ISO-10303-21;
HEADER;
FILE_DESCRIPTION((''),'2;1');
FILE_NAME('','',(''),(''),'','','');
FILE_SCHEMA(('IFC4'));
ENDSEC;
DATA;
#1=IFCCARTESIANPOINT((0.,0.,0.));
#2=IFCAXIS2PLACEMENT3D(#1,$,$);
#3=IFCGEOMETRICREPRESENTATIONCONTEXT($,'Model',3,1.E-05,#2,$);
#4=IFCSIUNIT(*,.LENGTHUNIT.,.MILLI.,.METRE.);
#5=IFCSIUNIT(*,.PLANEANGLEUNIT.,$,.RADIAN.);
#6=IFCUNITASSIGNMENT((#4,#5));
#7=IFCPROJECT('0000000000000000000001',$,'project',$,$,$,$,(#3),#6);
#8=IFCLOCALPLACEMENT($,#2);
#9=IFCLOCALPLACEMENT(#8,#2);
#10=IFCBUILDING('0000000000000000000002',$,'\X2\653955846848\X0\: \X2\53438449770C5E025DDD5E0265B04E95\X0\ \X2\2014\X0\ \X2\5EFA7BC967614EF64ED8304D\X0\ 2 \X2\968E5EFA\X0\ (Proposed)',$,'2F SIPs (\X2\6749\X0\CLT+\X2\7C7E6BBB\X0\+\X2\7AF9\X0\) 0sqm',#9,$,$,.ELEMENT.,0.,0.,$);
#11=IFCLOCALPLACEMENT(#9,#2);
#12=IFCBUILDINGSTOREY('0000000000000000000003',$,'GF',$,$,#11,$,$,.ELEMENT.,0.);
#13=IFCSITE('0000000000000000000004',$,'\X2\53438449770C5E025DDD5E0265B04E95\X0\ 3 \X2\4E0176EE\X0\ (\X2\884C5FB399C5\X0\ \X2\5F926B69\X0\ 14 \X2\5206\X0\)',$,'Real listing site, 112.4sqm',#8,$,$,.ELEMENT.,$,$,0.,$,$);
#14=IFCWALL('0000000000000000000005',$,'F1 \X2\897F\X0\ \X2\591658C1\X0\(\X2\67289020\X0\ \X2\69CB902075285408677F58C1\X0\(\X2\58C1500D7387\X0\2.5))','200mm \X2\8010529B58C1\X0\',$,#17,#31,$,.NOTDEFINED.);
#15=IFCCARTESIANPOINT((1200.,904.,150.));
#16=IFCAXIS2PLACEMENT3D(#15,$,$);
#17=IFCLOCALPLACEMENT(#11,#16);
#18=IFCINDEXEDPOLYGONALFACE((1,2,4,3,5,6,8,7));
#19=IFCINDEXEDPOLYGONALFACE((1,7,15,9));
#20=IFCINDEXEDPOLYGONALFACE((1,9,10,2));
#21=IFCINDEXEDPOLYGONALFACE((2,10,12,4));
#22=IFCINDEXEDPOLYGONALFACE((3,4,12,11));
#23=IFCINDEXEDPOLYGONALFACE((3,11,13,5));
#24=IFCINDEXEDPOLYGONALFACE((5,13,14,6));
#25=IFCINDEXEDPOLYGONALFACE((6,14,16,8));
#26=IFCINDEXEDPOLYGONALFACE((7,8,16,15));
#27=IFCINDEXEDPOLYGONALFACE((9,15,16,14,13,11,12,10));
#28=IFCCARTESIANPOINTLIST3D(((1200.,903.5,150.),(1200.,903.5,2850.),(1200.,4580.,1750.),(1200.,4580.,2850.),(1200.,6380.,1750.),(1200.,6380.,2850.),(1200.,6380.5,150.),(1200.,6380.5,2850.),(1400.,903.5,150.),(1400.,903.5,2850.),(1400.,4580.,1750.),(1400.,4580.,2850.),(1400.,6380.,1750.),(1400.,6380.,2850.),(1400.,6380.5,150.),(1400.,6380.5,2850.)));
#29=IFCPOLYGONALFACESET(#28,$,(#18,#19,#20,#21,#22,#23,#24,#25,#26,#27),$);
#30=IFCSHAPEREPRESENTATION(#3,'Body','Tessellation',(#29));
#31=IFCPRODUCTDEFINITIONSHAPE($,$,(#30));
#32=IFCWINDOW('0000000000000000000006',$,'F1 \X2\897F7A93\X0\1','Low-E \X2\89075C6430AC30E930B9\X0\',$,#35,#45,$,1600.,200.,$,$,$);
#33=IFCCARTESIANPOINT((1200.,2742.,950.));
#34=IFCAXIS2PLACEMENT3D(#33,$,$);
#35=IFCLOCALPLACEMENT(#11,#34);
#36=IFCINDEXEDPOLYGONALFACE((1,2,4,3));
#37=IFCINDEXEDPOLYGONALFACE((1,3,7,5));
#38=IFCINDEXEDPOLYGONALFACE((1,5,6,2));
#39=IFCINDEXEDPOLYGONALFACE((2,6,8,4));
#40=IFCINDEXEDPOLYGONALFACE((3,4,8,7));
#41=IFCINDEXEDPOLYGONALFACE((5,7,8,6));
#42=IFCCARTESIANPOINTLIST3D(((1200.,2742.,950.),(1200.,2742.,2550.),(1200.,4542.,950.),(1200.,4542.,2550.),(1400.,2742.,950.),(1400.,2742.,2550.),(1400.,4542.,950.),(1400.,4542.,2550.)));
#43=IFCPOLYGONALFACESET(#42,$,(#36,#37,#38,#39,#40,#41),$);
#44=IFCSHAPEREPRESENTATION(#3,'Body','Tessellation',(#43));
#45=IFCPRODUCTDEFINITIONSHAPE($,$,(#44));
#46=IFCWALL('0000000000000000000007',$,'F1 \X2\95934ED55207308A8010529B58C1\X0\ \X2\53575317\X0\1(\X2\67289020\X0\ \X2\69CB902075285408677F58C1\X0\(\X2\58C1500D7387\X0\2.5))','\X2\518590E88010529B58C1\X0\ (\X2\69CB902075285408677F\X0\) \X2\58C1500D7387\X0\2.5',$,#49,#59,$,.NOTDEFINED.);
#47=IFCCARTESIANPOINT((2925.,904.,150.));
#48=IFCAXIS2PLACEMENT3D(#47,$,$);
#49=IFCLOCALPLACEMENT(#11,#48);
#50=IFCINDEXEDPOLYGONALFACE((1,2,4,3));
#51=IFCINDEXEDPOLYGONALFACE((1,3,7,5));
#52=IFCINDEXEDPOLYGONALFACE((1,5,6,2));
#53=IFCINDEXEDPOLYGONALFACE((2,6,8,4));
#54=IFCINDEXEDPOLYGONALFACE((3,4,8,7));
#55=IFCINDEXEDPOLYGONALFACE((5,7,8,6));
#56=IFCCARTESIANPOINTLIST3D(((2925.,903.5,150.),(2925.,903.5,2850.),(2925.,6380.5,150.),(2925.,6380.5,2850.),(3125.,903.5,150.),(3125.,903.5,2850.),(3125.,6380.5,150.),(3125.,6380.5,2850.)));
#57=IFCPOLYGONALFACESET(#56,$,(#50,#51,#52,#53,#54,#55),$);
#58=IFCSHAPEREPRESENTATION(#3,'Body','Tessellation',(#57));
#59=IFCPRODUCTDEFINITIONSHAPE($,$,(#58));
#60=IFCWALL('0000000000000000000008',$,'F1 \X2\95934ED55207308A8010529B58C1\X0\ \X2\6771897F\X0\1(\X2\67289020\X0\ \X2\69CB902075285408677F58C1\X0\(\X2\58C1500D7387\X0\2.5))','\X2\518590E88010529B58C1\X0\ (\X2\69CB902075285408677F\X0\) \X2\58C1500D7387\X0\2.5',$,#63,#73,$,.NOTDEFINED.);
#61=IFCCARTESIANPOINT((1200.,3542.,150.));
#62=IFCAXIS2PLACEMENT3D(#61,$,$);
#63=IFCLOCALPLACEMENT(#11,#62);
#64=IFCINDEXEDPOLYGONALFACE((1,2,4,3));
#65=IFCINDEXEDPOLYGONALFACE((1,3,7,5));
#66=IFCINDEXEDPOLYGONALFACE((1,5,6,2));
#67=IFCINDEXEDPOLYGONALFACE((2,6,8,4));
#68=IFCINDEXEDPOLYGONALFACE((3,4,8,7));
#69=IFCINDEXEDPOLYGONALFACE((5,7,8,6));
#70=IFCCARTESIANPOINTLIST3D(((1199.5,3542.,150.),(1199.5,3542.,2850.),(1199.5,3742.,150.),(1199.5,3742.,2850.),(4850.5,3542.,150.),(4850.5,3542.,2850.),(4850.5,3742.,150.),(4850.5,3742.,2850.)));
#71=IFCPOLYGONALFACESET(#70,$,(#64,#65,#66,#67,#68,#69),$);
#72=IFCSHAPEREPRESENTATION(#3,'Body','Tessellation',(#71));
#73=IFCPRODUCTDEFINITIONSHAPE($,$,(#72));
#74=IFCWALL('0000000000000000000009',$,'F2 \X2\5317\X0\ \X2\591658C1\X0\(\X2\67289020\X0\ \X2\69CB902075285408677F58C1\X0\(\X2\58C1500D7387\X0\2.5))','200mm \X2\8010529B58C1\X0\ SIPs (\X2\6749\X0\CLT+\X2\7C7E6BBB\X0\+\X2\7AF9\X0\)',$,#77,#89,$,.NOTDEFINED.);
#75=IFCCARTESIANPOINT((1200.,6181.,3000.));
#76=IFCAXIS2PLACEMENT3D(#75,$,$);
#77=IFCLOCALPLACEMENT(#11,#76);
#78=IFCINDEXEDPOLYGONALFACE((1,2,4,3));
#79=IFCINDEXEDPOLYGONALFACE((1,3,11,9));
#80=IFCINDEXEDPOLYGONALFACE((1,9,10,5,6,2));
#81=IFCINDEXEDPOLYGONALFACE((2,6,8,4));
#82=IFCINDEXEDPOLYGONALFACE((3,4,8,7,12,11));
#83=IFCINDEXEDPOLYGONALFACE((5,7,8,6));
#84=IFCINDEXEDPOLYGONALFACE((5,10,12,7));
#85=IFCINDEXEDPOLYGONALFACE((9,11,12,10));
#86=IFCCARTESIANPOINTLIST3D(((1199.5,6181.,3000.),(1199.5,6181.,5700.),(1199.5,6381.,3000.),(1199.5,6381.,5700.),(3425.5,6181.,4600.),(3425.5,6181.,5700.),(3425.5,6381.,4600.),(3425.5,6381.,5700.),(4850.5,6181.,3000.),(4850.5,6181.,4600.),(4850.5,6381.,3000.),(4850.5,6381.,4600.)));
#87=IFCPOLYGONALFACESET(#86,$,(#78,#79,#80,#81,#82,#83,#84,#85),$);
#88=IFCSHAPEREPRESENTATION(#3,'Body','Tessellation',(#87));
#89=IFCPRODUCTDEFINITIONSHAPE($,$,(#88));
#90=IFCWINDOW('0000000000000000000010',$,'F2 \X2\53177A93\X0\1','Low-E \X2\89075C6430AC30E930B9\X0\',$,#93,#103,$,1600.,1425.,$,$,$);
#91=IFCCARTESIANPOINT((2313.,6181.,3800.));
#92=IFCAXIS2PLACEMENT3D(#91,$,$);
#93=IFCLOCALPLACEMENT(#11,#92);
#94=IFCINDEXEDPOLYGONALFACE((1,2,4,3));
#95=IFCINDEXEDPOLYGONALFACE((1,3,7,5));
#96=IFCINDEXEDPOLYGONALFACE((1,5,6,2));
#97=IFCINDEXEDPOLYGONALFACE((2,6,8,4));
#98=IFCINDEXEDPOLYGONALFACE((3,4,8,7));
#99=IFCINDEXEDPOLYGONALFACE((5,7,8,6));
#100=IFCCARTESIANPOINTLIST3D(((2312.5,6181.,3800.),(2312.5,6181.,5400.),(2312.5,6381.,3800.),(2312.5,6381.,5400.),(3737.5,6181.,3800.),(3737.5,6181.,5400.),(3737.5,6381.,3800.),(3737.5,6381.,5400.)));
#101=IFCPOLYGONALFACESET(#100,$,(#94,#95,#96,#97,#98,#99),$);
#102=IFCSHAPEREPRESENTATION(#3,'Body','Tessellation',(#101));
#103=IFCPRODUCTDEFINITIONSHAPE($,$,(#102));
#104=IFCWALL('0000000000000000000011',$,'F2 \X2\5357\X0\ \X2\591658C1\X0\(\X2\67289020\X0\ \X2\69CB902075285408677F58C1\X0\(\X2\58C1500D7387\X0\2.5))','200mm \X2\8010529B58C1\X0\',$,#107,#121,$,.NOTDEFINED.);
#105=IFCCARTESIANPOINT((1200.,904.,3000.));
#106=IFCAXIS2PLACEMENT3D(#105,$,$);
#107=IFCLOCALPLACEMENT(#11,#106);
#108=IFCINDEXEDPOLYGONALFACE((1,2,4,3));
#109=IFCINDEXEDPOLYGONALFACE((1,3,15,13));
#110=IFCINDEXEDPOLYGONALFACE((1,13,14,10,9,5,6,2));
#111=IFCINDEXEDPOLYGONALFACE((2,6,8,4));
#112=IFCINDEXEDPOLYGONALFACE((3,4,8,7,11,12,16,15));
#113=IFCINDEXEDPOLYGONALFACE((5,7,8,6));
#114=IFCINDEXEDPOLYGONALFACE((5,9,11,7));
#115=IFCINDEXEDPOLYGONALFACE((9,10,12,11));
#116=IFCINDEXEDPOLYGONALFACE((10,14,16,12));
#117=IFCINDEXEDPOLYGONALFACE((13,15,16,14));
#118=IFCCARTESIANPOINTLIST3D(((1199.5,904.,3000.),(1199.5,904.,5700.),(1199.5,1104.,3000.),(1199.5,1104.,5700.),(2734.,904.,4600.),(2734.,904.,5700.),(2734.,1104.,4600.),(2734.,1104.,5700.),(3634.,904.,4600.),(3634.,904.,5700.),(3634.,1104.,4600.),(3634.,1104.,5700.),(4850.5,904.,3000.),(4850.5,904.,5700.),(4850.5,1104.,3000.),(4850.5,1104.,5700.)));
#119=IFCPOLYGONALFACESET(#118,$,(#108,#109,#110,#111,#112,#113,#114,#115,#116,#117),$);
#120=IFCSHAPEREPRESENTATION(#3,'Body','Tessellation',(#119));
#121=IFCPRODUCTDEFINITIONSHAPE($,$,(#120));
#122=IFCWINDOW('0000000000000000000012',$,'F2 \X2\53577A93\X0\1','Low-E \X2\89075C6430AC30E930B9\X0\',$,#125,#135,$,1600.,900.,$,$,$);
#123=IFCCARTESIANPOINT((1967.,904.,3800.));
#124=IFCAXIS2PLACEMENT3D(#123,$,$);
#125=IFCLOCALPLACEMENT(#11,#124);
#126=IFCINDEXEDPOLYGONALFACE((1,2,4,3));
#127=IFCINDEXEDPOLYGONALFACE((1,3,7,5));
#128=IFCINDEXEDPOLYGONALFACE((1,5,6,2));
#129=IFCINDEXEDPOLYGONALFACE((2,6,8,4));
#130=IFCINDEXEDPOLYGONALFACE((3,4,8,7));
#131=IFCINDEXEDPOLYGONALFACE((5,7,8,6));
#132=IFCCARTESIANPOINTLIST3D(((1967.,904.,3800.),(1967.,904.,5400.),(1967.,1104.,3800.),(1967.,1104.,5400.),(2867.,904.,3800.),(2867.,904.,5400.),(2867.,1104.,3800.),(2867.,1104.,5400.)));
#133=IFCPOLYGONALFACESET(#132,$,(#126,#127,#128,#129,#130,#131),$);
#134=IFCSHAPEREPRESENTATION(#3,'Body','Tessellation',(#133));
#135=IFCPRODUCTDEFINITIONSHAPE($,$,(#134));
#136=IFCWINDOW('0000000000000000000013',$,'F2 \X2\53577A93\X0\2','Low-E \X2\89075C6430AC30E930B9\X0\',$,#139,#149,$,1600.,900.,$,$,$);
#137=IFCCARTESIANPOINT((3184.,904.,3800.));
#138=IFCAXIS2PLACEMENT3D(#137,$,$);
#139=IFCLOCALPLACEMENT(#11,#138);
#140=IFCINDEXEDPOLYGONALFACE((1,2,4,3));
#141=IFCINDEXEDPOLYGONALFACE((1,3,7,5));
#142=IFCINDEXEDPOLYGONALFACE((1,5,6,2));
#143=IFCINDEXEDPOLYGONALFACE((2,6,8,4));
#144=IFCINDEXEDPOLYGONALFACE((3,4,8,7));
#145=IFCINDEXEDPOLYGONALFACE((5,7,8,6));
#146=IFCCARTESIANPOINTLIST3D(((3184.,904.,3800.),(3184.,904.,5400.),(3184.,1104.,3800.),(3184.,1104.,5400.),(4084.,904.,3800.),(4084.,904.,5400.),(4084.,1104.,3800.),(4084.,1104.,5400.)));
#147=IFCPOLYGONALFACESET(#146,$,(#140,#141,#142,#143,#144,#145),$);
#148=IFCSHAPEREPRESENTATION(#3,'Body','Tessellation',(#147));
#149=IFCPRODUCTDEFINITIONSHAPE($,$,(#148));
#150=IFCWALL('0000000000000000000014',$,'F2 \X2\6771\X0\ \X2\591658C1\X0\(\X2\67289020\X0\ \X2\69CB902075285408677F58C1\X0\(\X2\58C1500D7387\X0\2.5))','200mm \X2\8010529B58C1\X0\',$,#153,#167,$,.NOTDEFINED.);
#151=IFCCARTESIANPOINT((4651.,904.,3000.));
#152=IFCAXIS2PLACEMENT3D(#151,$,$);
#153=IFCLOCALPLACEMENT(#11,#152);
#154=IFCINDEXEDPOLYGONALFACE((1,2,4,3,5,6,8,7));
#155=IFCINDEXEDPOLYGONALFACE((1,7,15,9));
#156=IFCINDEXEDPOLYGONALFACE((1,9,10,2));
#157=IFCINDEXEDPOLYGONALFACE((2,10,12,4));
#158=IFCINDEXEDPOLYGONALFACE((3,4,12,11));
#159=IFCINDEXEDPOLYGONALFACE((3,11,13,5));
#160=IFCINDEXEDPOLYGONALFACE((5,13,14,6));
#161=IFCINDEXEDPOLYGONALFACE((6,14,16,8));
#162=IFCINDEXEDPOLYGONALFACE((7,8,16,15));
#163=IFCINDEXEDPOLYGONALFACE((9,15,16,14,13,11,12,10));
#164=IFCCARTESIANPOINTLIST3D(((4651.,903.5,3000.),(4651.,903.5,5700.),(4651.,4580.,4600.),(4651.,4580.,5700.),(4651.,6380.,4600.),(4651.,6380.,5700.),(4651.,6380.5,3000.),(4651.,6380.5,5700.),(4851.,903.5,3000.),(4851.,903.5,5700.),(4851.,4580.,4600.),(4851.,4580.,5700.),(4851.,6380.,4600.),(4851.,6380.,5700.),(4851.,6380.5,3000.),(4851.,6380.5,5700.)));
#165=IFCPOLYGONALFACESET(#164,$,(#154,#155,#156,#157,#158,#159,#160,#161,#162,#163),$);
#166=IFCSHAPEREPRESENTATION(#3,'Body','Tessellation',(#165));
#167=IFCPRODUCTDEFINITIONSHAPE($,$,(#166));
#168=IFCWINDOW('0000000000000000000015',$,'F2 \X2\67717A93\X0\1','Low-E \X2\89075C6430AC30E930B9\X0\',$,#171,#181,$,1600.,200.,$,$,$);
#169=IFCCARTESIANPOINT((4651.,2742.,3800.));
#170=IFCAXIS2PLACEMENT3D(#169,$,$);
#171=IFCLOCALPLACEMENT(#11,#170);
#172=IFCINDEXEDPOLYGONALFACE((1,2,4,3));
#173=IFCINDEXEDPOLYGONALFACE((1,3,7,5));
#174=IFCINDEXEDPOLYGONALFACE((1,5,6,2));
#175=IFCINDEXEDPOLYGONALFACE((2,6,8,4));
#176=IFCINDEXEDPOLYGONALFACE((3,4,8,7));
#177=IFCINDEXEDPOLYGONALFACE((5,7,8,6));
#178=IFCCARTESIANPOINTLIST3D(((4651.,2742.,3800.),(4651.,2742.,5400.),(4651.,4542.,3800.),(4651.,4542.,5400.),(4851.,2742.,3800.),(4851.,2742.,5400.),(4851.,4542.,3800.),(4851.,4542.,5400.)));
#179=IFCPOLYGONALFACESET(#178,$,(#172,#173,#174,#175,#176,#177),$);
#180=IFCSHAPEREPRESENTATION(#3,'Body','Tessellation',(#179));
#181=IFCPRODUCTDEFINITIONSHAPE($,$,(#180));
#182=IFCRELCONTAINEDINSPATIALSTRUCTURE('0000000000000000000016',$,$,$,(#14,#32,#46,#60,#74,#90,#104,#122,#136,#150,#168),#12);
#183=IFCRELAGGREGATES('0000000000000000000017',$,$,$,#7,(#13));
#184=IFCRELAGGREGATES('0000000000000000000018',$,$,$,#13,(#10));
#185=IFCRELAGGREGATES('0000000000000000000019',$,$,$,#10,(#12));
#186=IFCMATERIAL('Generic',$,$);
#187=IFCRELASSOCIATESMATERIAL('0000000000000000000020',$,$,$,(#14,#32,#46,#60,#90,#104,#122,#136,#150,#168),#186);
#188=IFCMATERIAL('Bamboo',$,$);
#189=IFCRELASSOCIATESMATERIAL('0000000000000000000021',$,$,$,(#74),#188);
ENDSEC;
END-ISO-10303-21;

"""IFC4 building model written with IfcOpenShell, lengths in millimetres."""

from ifc_helpers import new_model, si_unit, frame, frame_2d, origin, place, context, project, spatial, rectangle, extrude, material, element, fill, save


model = new_model("IFC4")

# Units and contexts
model_context = context("Model", 3, precision=1e-05, world=origin())
ifc_project = project(units=[si_unit("LENGTHUNIT", "METRE", prefix="MILLI"), si_unit("PLANEANGLEUNIT", "RADIAN")], contexts=[model_context])

# Site, building, storey
site_placement = place(None, origin())
site = spatial("IfcSite", under=ifc_project, at=site_placement, Name="千葉県市川市新井 3 丁目 (行徳駅 徒歩 14 分)", ObjectType="Real listing site, 112.4sqm", CompositionType="ELEMENT", RefElevation=0.0)
building_placement = place(site_placement, origin())
building = spatial("IfcBuilding", under=site, at=building_placement, Name="改善案: 千葉県市川市新井 — 建築条件付き 2 階建 (Proposed)", ObjectType="2F SIPs (杉CLT+籾殻+竹) 0sqm", CompositionType="ELEMENT", ElevationOfRefHeight=0.0, ElevationOfTerrain=0.0)
storey_placement = place(building_placement, origin())
storey = spatial("IfcBuildingStorey", under=building, at=storey_placement, Name="GF", CompositionType="ELEMENT", Elevation=0.0)

# Shared definitions
ifc_material_1 = material(Name="Generic")

# Shared definitions
ifc_material_2 = material(Name="Bamboo")

# Wall, opening, window
wall_1_placement = place(storey_placement, frame((1200.0, 904.0, 150.0)))
wall_1 = element("IfcWall", 1, at=wall_1_placement, inside=storey, material=ifc_material_1, Name="F1 西 外壁(木造 構造用合板壁(壁倍率2.5))", Description="200mm 耐力壁", PredefinedType="NOTDEFINED", context=model_context, shape_type="SweptSolid", body=[
    extrude(rectangle(XDim=200.0, YDim=5477.0, at=frame_2d((100.0, 2738.0))), frame((1200.0, 904.0, 150.0)), (0.0, 0.0, 1.0), 2700.0),
])
opening_1_placement = place(storey_placement, frame((1200.0, 2742.0, 950.0)))
opening_1 = element("IfcOpeningElement", 2, at=opening_1_placement, cuts=wall_1, PredefinedType="NOTDEFINED", context=model_context, shape_type="SweptSolid", body=[
    extrude(rectangle(XDim=200.0, YDim=1800.0, at=frame_2d((100.0, 900.0))), frame((1200.0, 2742.0, 950.0)), (0.0, 0.0, 1.0), 1600.0),
])
window_1_placement = place(storey_placement, frame((1200.0, 2742.0, 950.0)))
window_1 = element("IfcWindow", 3, at=window_1_placement, inside=storey, material=ifc_material_1, Name="F1 西窓1", Description="Low-E 複層ガラス", OverallHeight=1600.0, OverallWidth=200.0, context=model_context, shape_type="SweptSolid", body=[
    extrude(rectangle(XDim=200.0, YDim=1800.0, at=frame_2d((100.0, 900.0))), frame((1200.0, 2742.0, 950.0)), (0.0, 0.0, 1.0), 1600.0),
])
fill(opening_1, window_1)

# Walls
wall_2_placement = place(storey_placement, frame((2925.0, 904.0, 150.0)))
element("IfcWall", 4, at=wall_2_placement, inside=storey, material=ifc_material_1, Name="F1 間仕切り耐力壁 南北1(木造 構造用合板壁(壁倍率2.5))", Description="内部耐力壁 (構造用合板) 壁倍率2.5", PredefinedType="NOTDEFINED", context=model_context, shape_type="SweptSolid", body=[
    extrude(rectangle(XDim=200.0, YDim=5477.0, at=frame_2d((100.0, 2738.0))), frame((2925.0, 904.0, 150.0)), (0.0, 0.0, 1.0), 2700.0),
])
wall_3_placement = place(storey_placement, frame((1200.0, 3542.0, 150.0)))
element("IfcWall", 5, at=wall_3_placement, inside=storey, material=ifc_material_1, Name="F1 間仕切り耐力壁 東西1(木造 構造用合板壁(壁倍率2.5))", Description="内部耐力壁 (構造用合板) 壁倍率2.5", PredefinedType="NOTDEFINED", context=model_context, shape_type="SweptSolid", body=[
    extrude(rectangle(XDim=3651.0, YDim=200.0, at=frame_2d((1825.0, 100.0))), frame((1200.0, 3542.0, 150.0)), (0.0, 0.0, 1.0), 2700.0),
])

# Wall, opening, window
wall_4_placement = place(storey_placement, frame((1200.0, 6181.0, 3000.0)))
wall_4 = element("IfcWall", 6, at=wall_4_placement, inside=storey, material=ifc_material_2, Name="F2 北 外壁(木造 構造用合板壁(壁倍率2.5))", Description="200mm 耐力壁 SIPs (杉CLT+籾殻+竹)", PredefinedType="NOTDEFINED", context=model_context, shape_type="SweptSolid", body=[
    extrude(rectangle(XDim=3651.0, YDim=200.0, at=frame_2d((1825.0, 100.0))), frame((1200.0, 6181.0, 3000.0)), (0.0, 0.0, 1.0), 2700.0),
])
opening_2_placement = place(storey_placement, frame((2313.0, 6181.0, 3800.0)))
opening_2 = element("IfcOpeningElement", 7, at=opening_2_placement, cuts=wall_4, PredefinedType="NOTDEFINED", context=model_context, shape_type="SweptSolid", body=[
    extrude(rectangle(XDim=1425.0, YDim=200.0, at=frame_2d((712.0, 100.0))), frame((2313.0, 6181.0, 3800.0)), (0.0, 0.0, 1.0), 1600.0),
])
window_2_placement = place(storey_placement, frame((2313.0, 6181.0, 3800.0)))
window_2 = element("IfcWindow", 8, at=window_2_placement, inside=storey, material=ifc_material_1, Name="F2 北窓1", Description="Low-E 複層ガラス", OverallHeight=1600.0, OverallWidth=1425.0, context=model_context, shape_type="SweptSolid", body=[
    extrude(rectangle(XDim=1425.0, YDim=200.0, at=frame_2d((712.0, 100.0))), frame((2313.0, 6181.0, 3800.0)), (0.0, 0.0, 1.0), 1600.0),
])
fill(opening_2, window_2)

# Wall, openings, windows
wall_5_placement = place(storey_placement, frame((1200.0, 904.0, 3000.0)))
wall_5 = element("IfcWall", 9, at=wall_5_placement, inside=storey, material=ifc_material_1, Name="F2 南 外壁(木造 構造用合板壁(壁倍率2.5))", Description="200mm 耐力壁", PredefinedType="NOTDEFINED", context=model_context, shape_type="SweptSolid", body=[
    extrude(rectangle(XDim=3651.0, YDim=200.0, at=frame_2d((1825.0, 100.0))), frame((1200.0, 904.0, 3000.0)), (0.0, 0.0, 1.0), 2700.0),
])
opening_3_placement = place(storey_placement, frame((1967.0, 904.0, 3800.0)))
opening_3 = element("IfcOpeningElement", 10, at=opening_3_placement, cuts=wall_5, PredefinedType="NOTDEFINED", context=model_context, shape_type="SweptSolid", body=[
    extrude(rectangle(XDim=900.0, YDim=200.0, at=frame_2d((450.0, 100.0))), frame((1967.0, 904.0, 3800.0)), (0.0, 0.0, 1.0), 1600.0),
])
opening_4_placement = place(storey_placement, frame((3184.0, 904.0, 3800.0)))
opening_4 = element("IfcOpeningElement", 11, at=opening_4_placement, cuts=wall_5, PredefinedType="NOTDEFINED", context=model_context, shape_type="SweptSolid", body=[
    extrude(rectangle(XDim=900.0, YDim=200.0, at=frame_2d((450.0, 100.0))), frame((3184.0, 904.0, 3800.0)), (0.0, 0.0, 1.0), 1600.0),
])
window_3_placement = place(storey_placement, frame((1967.0, 904.0, 3800.0)))
window_3 = element("IfcWindow", 12, at=window_3_placement, inside=storey, material=ifc_material_1, Name="F2 南窓1", Description="Low-E 複層ガラス", OverallHeight=1600.0, OverallWidth=900.0, context=model_context, shape_type="SweptSolid", body=[
    extrude(rectangle(XDim=900.0, YDim=200.0, at=frame_2d((450.0, 100.0))), frame((1967.0, 904.0, 3800.0)), (0.0, 0.0, 1.0), 1600.0),
])
fill(opening_3, window_3)
window_4_placement = place(storey_placement, frame((3184.0, 904.0, 3800.0)))
window_4 = element("IfcWindow", 13, at=window_4_placement, inside=storey, material=ifc_material_1, Name="F2 南窓2", Description="Low-E 複層ガラス", OverallHeight=1600.0, OverallWidth=900.0, context=model_context, shape_type="SweptSolid", body=[
    extrude(rectangle(XDim=900.0, YDim=200.0, at=frame_2d((450.0, 100.0))), frame((3184.0, 904.0, 3800.0)), (0.0, 0.0, 1.0), 1600.0),
])
fill(opening_4, window_4)

# Wall, opening, window
wall_6_placement = place(storey_placement, frame((4651.0, 904.0, 3000.0)))
wall_6 = element("IfcWall", 14, at=wall_6_placement, inside=storey, material=ifc_material_1, Name="F2 東 外壁(木造 構造用合板壁(壁倍率2.5))", Description="200mm 耐力壁", PredefinedType="NOTDEFINED", context=model_context, shape_type="SweptSolid", body=[
    extrude(rectangle(XDim=200.0, YDim=5477.0, at=frame_2d((100.0, 2738.0))), frame((4651.0, 904.0, 3000.0)), (0.0, 0.0, 1.0), 2700.0),
])
opening_5_placement = place(storey_placement, frame((4651.0, 2742.0, 3800.0)))
opening_5 = element("IfcOpeningElement", 15, at=opening_5_placement, cuts=wall_6, PredefinedType="NOTDEFINED", context=model_context, shape_type="SweptSolid", body=[
    extrude(rectangle(XDim=200.0, YDim=1800.0, at=frame_2d((100.0, 900.0))), frame((4651.0, 2742.0, 3800.0)), (0.0, 0.0, 1.0), 1600.0),
])
window_5_placement = place(storey_placement, frame((4651.0, 2742.0, 3800.0)))
window_5 = element("IfcWindow", 16, at=window_5_placement, inside=storey, material=ifc_material_1, Name="F2 東窓1", Description="Low-E 複層ガラス", OverallHeight=1600.0, OverallWidth=200.0, context=model_context, shape_type="SweptSolid", body=[
    extrude(rectangle(XDim=200.0, YDim=1800.0, at=frame_2d((100.0, 900.0))), frame((4651.0, 2742.0, 3800.0)), (0.0, 0.0, 1.0), 1600.0),
])
fill(opening_5, window_5)

save(model, "model.ifc")
